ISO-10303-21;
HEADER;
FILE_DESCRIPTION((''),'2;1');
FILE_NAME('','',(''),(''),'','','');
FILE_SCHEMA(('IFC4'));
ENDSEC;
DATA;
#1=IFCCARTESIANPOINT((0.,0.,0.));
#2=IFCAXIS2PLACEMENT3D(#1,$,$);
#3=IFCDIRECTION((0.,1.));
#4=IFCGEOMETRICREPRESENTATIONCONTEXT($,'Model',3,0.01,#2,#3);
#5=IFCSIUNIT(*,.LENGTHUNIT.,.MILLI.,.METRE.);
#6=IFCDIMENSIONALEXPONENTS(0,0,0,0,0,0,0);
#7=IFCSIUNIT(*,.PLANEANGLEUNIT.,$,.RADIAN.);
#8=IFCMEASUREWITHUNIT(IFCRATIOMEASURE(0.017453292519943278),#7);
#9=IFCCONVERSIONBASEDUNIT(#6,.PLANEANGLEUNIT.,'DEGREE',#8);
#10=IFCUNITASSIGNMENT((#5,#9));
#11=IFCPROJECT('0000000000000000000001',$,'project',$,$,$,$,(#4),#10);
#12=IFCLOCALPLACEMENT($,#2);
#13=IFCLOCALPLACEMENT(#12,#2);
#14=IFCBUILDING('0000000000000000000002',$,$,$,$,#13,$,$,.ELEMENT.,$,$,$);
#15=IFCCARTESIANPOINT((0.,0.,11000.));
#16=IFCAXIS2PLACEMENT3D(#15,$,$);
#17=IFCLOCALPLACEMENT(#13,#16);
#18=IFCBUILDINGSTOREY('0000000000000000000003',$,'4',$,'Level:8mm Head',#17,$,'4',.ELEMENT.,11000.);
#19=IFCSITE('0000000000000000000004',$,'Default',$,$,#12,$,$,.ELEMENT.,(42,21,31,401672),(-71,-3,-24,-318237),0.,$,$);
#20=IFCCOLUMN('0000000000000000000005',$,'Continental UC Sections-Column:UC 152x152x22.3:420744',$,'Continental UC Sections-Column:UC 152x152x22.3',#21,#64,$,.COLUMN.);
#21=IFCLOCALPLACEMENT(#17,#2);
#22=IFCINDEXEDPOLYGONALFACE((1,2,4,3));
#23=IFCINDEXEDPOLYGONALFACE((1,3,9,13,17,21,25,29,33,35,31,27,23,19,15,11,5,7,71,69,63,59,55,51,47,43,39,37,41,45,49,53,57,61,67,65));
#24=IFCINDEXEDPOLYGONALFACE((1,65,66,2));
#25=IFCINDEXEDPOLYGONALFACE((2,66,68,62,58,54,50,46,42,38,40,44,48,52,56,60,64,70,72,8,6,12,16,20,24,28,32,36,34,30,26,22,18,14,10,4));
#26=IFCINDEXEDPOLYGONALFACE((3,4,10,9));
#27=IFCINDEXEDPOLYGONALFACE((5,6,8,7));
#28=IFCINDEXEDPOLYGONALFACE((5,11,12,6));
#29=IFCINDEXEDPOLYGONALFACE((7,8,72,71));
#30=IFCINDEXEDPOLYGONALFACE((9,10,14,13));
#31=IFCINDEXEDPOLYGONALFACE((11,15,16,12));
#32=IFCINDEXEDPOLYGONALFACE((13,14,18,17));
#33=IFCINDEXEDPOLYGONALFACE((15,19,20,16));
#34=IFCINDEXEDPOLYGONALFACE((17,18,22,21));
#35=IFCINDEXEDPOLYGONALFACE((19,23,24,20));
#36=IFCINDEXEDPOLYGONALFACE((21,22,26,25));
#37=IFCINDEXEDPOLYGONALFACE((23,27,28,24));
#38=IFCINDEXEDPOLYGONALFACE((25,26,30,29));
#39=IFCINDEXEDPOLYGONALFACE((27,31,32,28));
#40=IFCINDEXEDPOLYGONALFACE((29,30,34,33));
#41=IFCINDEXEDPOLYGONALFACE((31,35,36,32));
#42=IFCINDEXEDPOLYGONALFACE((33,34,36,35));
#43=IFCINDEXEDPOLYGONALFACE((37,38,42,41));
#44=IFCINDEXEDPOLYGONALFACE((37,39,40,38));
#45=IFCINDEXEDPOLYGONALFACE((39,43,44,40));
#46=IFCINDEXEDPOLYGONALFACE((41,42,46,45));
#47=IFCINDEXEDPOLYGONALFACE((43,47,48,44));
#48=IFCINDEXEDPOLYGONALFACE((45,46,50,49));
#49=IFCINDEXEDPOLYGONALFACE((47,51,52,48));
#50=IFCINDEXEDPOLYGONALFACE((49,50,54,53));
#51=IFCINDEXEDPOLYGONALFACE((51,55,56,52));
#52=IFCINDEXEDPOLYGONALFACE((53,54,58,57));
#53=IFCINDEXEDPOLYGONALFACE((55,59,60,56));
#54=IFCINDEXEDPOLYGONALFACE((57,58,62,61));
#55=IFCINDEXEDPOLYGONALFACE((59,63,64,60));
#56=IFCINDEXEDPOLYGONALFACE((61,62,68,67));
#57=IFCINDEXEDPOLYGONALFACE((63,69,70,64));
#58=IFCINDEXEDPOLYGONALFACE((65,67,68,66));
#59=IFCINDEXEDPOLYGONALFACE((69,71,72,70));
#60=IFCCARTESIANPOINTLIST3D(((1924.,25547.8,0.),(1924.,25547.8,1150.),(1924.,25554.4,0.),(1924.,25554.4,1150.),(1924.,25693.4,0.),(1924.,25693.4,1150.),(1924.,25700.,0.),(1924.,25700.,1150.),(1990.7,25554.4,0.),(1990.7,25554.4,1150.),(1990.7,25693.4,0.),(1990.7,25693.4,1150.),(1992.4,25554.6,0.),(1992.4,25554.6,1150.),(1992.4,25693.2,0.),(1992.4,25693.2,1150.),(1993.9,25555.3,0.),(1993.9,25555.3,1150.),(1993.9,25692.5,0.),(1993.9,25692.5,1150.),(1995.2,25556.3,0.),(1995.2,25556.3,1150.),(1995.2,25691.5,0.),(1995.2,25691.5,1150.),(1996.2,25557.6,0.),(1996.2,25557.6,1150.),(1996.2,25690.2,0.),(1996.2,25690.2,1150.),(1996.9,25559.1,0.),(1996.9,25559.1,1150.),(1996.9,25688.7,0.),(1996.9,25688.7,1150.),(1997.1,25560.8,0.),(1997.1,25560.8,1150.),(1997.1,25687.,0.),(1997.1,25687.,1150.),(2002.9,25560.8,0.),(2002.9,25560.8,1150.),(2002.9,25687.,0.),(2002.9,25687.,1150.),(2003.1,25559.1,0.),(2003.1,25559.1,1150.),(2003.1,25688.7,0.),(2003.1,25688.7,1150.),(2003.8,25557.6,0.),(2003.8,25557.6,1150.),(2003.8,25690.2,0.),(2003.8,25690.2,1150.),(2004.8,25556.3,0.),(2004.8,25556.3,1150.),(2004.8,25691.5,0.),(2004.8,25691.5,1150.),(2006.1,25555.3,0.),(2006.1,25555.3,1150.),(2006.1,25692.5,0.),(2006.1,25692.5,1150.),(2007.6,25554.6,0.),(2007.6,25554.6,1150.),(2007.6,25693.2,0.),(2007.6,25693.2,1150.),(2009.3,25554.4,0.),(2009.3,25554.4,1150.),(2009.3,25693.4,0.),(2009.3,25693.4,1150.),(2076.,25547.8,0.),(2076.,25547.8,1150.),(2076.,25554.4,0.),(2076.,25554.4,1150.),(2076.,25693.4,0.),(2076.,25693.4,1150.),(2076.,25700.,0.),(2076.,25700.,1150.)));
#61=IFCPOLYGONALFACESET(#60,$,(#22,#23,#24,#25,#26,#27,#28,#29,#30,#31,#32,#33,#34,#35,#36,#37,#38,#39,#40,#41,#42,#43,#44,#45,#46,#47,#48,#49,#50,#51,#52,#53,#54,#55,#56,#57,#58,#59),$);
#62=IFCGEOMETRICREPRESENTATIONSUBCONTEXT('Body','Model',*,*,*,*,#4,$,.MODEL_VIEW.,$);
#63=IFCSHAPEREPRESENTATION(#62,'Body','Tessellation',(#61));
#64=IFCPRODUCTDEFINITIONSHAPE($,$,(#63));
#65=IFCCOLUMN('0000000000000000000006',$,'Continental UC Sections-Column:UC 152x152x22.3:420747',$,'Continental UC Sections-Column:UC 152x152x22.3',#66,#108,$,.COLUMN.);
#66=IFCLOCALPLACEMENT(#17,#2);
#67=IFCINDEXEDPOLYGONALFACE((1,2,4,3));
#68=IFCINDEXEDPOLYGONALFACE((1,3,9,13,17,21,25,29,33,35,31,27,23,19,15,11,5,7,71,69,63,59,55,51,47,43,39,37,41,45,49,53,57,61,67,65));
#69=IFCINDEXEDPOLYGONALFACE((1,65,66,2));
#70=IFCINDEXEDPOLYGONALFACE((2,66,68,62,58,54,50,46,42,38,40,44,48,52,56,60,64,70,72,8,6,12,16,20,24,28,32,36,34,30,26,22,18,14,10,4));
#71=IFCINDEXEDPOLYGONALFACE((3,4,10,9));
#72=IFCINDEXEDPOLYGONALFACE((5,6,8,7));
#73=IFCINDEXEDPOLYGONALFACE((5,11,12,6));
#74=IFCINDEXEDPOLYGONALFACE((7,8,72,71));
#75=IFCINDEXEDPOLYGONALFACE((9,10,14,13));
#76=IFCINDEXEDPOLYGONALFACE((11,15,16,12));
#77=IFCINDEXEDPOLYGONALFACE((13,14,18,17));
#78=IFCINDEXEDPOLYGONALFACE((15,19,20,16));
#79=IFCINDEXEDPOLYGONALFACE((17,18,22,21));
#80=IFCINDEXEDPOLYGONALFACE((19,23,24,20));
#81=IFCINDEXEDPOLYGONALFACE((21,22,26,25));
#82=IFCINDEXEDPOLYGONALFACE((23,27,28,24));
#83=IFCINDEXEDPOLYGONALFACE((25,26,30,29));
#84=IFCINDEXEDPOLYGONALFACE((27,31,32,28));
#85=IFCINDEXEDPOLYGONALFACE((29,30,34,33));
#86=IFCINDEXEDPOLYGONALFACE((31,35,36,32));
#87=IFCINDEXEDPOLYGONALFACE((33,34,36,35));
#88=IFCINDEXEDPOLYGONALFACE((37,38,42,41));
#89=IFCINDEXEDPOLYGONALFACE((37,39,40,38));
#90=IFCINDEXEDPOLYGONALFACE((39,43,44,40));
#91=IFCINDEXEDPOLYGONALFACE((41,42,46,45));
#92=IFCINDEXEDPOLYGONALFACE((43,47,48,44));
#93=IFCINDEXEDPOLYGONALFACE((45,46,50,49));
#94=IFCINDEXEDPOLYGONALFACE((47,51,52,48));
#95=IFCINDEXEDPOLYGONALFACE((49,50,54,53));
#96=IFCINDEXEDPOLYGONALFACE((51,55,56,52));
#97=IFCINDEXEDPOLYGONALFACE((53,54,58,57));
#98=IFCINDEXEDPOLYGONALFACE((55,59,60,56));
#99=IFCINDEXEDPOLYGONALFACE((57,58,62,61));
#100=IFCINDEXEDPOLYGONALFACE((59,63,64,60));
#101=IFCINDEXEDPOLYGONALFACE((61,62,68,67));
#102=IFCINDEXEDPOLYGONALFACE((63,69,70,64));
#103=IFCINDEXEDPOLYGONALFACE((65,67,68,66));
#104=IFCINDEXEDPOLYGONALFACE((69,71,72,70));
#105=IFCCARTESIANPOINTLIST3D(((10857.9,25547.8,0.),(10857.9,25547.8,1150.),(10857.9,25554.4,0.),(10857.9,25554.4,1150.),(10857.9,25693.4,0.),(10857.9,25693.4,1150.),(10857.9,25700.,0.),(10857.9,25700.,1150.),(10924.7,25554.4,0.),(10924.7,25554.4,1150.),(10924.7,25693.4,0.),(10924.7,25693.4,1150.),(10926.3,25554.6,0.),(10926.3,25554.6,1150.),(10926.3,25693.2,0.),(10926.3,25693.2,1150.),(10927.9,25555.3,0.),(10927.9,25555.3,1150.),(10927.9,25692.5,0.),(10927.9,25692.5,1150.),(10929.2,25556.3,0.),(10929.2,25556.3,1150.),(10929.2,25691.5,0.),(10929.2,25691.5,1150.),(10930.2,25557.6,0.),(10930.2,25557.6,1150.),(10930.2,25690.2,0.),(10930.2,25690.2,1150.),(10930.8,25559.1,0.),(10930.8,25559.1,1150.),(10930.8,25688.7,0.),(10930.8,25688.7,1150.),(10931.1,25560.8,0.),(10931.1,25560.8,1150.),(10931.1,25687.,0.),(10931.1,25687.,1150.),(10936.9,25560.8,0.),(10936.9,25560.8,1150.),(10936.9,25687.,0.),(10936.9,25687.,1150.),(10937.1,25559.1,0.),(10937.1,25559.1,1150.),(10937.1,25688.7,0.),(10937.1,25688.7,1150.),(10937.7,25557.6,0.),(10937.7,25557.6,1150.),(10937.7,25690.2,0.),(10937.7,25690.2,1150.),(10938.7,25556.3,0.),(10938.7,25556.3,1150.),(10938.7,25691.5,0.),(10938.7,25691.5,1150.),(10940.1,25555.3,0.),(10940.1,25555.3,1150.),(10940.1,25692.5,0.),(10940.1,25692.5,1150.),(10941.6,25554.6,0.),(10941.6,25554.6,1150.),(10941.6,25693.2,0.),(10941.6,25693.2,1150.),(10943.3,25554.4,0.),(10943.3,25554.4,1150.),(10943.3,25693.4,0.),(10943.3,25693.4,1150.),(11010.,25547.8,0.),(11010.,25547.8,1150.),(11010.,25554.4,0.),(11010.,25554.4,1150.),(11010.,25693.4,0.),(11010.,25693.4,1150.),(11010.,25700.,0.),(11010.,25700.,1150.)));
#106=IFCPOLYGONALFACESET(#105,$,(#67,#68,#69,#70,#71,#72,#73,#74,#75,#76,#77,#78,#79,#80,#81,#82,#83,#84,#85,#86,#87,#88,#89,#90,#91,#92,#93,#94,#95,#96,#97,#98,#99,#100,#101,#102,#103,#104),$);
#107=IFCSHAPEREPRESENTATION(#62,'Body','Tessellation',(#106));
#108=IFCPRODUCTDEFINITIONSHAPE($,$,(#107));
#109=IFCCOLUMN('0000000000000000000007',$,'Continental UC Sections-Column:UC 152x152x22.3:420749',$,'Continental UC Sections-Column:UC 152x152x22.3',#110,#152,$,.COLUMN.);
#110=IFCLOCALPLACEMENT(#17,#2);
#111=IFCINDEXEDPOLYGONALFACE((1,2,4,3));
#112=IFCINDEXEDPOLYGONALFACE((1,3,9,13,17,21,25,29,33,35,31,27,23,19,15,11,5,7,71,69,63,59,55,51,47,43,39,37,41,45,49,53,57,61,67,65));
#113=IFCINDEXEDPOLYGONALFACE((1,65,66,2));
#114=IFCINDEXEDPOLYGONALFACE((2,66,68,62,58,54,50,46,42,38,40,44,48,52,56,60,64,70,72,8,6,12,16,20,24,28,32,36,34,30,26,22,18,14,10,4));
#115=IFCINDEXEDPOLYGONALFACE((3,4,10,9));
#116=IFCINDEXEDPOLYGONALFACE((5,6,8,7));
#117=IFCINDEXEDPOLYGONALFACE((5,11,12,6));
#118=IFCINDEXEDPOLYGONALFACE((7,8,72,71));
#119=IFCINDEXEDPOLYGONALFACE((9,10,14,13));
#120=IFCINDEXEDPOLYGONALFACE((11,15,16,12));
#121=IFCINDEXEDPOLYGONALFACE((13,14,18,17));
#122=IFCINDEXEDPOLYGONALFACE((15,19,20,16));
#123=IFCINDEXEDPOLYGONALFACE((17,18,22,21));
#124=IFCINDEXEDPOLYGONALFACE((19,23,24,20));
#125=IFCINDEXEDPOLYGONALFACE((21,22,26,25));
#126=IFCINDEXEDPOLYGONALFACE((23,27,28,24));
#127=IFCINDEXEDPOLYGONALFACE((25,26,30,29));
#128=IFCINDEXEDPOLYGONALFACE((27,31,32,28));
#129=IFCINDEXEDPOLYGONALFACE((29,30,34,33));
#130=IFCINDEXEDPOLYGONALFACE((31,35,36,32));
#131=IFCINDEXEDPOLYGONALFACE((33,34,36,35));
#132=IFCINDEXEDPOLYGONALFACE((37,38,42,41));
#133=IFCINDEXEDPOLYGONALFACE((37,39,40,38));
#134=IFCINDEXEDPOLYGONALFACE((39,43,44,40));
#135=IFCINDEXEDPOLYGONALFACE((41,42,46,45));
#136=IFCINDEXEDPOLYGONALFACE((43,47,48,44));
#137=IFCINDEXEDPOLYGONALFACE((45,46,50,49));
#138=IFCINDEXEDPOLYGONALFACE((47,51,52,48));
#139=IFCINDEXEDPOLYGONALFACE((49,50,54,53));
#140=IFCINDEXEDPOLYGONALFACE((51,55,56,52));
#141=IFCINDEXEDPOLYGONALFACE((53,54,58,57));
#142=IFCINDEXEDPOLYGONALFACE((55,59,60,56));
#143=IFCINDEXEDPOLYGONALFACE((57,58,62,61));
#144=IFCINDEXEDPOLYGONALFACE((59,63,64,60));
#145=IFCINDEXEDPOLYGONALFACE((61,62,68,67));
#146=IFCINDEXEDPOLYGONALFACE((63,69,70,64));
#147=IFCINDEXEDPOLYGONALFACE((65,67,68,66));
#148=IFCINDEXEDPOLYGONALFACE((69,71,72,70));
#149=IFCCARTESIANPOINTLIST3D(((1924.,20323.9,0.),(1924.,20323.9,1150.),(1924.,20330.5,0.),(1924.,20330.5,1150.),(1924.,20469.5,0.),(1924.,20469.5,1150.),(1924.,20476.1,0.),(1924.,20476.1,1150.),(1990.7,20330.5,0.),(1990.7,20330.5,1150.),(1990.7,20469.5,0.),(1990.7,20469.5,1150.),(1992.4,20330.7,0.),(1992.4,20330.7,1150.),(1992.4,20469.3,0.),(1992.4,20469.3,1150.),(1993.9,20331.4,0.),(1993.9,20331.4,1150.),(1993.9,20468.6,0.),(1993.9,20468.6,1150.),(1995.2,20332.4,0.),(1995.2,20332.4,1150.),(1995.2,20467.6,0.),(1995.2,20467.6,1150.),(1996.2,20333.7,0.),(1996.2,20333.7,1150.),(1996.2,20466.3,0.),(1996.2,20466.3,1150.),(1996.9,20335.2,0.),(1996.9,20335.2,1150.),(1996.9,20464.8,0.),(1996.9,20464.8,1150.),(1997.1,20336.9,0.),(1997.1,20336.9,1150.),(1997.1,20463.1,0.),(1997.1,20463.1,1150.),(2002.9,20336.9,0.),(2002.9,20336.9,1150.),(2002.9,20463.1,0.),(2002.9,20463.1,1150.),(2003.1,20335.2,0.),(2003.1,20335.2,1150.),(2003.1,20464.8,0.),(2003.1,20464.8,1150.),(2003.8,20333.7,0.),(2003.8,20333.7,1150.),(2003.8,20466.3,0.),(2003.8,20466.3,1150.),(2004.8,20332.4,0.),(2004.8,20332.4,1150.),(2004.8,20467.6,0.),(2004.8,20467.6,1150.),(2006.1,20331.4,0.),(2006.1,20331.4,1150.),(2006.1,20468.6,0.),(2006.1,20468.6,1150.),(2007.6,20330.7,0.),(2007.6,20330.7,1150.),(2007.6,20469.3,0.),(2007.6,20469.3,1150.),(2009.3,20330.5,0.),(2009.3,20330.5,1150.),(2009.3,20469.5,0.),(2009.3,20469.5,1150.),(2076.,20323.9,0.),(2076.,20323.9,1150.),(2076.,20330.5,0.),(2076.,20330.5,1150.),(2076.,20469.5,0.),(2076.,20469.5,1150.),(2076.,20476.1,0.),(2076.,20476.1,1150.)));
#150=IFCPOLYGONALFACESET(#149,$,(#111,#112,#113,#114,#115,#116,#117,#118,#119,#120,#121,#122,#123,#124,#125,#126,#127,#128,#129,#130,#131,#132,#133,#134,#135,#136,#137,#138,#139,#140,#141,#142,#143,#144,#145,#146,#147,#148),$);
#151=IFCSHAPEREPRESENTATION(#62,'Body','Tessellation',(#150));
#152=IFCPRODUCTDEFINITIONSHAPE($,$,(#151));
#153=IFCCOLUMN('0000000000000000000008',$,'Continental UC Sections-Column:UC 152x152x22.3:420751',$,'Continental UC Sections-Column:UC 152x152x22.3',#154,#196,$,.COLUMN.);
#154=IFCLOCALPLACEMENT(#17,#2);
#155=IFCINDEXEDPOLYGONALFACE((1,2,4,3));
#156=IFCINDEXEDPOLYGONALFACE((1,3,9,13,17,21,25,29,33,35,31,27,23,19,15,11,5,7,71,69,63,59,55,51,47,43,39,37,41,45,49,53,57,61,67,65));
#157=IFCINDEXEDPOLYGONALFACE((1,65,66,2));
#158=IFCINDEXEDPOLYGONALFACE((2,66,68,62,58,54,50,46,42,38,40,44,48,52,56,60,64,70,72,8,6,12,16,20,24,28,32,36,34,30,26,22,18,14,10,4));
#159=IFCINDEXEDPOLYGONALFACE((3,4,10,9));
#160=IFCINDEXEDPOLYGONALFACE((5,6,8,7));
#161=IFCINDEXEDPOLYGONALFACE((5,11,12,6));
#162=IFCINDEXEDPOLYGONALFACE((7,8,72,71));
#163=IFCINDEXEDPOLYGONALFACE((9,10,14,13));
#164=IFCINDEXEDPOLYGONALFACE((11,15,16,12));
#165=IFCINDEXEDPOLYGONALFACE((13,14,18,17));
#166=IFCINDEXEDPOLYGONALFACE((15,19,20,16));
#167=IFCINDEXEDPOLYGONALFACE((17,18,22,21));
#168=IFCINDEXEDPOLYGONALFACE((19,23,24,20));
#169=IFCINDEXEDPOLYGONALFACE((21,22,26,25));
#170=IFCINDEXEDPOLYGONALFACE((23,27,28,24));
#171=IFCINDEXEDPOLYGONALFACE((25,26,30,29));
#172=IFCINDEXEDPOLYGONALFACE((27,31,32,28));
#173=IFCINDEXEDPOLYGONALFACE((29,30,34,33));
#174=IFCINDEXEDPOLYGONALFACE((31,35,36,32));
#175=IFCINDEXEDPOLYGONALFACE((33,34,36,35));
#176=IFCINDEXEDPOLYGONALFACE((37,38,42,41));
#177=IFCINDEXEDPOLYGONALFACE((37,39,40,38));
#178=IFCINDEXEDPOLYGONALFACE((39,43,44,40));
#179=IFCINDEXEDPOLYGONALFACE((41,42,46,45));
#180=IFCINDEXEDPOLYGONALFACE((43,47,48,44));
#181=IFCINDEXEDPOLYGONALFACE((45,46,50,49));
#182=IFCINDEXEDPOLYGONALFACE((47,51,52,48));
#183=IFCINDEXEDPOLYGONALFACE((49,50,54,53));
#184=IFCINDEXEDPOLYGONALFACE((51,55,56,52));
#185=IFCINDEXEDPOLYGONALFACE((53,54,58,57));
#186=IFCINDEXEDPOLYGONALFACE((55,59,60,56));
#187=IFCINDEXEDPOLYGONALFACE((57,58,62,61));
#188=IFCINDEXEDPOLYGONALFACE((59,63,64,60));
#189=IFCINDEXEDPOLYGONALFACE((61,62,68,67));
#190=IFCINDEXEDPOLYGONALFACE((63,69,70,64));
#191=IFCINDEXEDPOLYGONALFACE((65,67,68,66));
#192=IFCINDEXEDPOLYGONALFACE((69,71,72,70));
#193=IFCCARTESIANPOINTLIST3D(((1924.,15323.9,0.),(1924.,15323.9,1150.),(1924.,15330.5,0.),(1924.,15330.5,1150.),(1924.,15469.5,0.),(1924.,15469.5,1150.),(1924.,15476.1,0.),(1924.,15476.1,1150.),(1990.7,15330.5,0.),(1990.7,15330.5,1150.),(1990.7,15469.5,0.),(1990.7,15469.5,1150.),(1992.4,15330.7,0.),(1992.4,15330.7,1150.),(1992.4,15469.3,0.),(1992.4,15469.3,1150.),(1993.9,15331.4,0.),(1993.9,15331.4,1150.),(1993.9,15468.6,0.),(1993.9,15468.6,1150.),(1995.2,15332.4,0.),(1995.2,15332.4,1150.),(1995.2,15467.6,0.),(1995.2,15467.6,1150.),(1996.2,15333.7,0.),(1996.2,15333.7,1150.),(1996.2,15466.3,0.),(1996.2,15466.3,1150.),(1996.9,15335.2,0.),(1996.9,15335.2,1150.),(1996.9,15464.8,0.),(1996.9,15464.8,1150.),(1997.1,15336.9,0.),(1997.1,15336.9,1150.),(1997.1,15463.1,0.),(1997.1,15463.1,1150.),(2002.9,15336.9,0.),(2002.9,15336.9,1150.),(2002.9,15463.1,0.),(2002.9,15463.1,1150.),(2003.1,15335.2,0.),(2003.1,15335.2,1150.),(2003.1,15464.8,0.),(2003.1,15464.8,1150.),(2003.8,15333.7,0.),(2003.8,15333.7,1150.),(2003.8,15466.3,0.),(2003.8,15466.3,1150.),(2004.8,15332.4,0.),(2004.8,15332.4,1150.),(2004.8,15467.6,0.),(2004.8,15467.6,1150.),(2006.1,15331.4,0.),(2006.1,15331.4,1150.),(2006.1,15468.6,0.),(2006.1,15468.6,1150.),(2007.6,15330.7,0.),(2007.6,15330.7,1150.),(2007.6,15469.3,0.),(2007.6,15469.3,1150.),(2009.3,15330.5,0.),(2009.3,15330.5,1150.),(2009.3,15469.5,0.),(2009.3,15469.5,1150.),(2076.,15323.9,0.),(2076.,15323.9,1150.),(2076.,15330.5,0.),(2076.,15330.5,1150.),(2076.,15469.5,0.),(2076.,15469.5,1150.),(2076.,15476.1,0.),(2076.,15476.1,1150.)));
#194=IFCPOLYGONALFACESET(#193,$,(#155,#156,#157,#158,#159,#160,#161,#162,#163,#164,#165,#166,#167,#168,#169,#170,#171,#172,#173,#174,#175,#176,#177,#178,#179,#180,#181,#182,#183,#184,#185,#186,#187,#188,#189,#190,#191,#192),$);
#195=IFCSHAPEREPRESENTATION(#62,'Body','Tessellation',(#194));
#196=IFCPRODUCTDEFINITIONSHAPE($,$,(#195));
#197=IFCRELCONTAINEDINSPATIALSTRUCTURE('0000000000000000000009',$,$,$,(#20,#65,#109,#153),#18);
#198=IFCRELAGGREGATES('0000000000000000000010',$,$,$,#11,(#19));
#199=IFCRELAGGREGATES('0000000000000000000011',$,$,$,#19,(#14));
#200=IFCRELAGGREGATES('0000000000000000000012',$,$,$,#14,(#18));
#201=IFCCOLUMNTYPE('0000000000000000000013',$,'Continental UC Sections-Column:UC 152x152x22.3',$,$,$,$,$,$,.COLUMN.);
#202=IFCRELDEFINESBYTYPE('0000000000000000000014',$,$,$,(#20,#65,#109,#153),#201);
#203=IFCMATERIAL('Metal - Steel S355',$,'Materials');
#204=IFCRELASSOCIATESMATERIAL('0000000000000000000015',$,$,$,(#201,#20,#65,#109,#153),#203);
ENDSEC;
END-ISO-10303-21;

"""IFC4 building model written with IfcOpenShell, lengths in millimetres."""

from ifc_helpers import new_model, entity, si_unit, converted_unit, direction, frame, origin, place, context, subcontext, project, spatial, line, arc, indexed_curve, outline, extrude, source, transform, mapped, material, type_object, type_shapes, element, save


model = new_model("IFC4")

# Units and contexts
model_context = context("Model", 3, precision=0.01, world=origin(), true_north=direction((0.0, 1.0)))
body_context = subcontext(model_context, "Body", "Model", "MODEL_VIEW")
ifc_project = project(units=[si_unit("LENGTHUNIT", "METRE", prefix="MILLI"), converted_unit("PLANEANGLEUNIT", "DEGREE", entity("IfcRatioMeasure", 0.017453292519943278), si_unit("PLANEANGLEUNIT", "RADIAN"), dimensions=[0, 0, 0, 0, 0, 0, 0])], contexts=[model_context])

# Site, building, storey
site_placement = place(None, origin())
site = spatial("IfcSite", under=ifc_project, at=site_placement, Name="Default", CompositionType="ELEMENT", RefLatitude=(42, 21, 31, 401672), RefLongitude=(-71, -3, -24, -318237), RefElevation=0.0)
building_placement = place(site_placement, origin())
building = spatial("IfcBuilding", under=site, at=building_placement, CompositionType="ELEMENT")
storey_placement = place(building_placement, frame((0.0, 0.0, 11000.0)))
storey = spatial("IfcBuildingStorey", under=building, at=storey_placement, Name="4", ObjectType="Level:8mm Head", LongName="4", CompositionType="ELEMENT", Elevation=11000.0)

# Columns
ifc_material_1 = material(Name="Metal - Steel S355", Category="Materials")
column_type_1 = type_object("IfcColumnType", Name="Continental UC Sections-Column:UC 152x152x22.3", PredefinedType="COLUMN", material=ifc_material_1)
shared_shape_1 = source(origin(), body_context, "Body", "SweptSolid", [
    extrude(outline(indexed_curve([(69.5, -76.0), (76.1, -76.0), (76.1, 76.0), (69.5, 76.0), (69.5, 9.3), (67.6, 4.8), (63.1, 2.9), (-63.1, 2.9), (-67.6, 4.8), (-69.5, 9.3), (-69.5, 76.0), (-76.1, 76.0), (-76.1, -76.0), (-69.5, -76.0), (-69.5, -9.3), (-67.6, -4.8), (-63.1, -2.9), (63.1, -2.9), (67.6, -4.8), (69.5, -9.3)], segments=[line(1, 2, 3, 4, 5), arc(5, 6, 7), line(7, 8), arc(8, 9, 10), line(10, 11, 12, 13, 14, 15), arc(15, 16, 17), line(17, 18), arc(18, 19, 20), line(20, 1)], self_intersect=False)), frame((0.0, 0.0, 11000.0), z_axis=(0.0, 0.0, 1.0), x_axis=(0.0, -1.0, 0.0)), (0.0, 0.0, 1.0), 1150.0),
])
type_shapes(column_type_1, [shared_shape_1])
for number, where, name in (
    (1, (2000.0, 25623.9, -11000.0), "Continental UC Sections-Column:UC 152x152x22.3:420744"),
    (2, (10934.0, 25623.9, -11000.0), "Continental UC Sections-Column:UC 152x152x22.3:420747"),
    (3, (2000.0, 20400.0, -11000.0), "Continental UC Sections-Column:UC 152x152x22.3:420749"),
    (4, (2000.0, 15400.0, -11000.0), "Continental UC Sections-Column:UC 152x152x22.3:420751"),
):
    element("IfcColumn", number, at=place(storey_placement, frame(where)), inside=storey, type_object=column_type_1, material=ifc_material_1, Name=name, ObjectType="Continental UC Sections-Column:UC 152x152x22.3", PredefinedType="COLUMN", context=body_context, shape_type="MappedRepresentation", body=[
        mapped(shared_shape_1, transform((0.0, 0.0, 0.0), scale=1.0)),
    ])

save(model, "model.ifc")
